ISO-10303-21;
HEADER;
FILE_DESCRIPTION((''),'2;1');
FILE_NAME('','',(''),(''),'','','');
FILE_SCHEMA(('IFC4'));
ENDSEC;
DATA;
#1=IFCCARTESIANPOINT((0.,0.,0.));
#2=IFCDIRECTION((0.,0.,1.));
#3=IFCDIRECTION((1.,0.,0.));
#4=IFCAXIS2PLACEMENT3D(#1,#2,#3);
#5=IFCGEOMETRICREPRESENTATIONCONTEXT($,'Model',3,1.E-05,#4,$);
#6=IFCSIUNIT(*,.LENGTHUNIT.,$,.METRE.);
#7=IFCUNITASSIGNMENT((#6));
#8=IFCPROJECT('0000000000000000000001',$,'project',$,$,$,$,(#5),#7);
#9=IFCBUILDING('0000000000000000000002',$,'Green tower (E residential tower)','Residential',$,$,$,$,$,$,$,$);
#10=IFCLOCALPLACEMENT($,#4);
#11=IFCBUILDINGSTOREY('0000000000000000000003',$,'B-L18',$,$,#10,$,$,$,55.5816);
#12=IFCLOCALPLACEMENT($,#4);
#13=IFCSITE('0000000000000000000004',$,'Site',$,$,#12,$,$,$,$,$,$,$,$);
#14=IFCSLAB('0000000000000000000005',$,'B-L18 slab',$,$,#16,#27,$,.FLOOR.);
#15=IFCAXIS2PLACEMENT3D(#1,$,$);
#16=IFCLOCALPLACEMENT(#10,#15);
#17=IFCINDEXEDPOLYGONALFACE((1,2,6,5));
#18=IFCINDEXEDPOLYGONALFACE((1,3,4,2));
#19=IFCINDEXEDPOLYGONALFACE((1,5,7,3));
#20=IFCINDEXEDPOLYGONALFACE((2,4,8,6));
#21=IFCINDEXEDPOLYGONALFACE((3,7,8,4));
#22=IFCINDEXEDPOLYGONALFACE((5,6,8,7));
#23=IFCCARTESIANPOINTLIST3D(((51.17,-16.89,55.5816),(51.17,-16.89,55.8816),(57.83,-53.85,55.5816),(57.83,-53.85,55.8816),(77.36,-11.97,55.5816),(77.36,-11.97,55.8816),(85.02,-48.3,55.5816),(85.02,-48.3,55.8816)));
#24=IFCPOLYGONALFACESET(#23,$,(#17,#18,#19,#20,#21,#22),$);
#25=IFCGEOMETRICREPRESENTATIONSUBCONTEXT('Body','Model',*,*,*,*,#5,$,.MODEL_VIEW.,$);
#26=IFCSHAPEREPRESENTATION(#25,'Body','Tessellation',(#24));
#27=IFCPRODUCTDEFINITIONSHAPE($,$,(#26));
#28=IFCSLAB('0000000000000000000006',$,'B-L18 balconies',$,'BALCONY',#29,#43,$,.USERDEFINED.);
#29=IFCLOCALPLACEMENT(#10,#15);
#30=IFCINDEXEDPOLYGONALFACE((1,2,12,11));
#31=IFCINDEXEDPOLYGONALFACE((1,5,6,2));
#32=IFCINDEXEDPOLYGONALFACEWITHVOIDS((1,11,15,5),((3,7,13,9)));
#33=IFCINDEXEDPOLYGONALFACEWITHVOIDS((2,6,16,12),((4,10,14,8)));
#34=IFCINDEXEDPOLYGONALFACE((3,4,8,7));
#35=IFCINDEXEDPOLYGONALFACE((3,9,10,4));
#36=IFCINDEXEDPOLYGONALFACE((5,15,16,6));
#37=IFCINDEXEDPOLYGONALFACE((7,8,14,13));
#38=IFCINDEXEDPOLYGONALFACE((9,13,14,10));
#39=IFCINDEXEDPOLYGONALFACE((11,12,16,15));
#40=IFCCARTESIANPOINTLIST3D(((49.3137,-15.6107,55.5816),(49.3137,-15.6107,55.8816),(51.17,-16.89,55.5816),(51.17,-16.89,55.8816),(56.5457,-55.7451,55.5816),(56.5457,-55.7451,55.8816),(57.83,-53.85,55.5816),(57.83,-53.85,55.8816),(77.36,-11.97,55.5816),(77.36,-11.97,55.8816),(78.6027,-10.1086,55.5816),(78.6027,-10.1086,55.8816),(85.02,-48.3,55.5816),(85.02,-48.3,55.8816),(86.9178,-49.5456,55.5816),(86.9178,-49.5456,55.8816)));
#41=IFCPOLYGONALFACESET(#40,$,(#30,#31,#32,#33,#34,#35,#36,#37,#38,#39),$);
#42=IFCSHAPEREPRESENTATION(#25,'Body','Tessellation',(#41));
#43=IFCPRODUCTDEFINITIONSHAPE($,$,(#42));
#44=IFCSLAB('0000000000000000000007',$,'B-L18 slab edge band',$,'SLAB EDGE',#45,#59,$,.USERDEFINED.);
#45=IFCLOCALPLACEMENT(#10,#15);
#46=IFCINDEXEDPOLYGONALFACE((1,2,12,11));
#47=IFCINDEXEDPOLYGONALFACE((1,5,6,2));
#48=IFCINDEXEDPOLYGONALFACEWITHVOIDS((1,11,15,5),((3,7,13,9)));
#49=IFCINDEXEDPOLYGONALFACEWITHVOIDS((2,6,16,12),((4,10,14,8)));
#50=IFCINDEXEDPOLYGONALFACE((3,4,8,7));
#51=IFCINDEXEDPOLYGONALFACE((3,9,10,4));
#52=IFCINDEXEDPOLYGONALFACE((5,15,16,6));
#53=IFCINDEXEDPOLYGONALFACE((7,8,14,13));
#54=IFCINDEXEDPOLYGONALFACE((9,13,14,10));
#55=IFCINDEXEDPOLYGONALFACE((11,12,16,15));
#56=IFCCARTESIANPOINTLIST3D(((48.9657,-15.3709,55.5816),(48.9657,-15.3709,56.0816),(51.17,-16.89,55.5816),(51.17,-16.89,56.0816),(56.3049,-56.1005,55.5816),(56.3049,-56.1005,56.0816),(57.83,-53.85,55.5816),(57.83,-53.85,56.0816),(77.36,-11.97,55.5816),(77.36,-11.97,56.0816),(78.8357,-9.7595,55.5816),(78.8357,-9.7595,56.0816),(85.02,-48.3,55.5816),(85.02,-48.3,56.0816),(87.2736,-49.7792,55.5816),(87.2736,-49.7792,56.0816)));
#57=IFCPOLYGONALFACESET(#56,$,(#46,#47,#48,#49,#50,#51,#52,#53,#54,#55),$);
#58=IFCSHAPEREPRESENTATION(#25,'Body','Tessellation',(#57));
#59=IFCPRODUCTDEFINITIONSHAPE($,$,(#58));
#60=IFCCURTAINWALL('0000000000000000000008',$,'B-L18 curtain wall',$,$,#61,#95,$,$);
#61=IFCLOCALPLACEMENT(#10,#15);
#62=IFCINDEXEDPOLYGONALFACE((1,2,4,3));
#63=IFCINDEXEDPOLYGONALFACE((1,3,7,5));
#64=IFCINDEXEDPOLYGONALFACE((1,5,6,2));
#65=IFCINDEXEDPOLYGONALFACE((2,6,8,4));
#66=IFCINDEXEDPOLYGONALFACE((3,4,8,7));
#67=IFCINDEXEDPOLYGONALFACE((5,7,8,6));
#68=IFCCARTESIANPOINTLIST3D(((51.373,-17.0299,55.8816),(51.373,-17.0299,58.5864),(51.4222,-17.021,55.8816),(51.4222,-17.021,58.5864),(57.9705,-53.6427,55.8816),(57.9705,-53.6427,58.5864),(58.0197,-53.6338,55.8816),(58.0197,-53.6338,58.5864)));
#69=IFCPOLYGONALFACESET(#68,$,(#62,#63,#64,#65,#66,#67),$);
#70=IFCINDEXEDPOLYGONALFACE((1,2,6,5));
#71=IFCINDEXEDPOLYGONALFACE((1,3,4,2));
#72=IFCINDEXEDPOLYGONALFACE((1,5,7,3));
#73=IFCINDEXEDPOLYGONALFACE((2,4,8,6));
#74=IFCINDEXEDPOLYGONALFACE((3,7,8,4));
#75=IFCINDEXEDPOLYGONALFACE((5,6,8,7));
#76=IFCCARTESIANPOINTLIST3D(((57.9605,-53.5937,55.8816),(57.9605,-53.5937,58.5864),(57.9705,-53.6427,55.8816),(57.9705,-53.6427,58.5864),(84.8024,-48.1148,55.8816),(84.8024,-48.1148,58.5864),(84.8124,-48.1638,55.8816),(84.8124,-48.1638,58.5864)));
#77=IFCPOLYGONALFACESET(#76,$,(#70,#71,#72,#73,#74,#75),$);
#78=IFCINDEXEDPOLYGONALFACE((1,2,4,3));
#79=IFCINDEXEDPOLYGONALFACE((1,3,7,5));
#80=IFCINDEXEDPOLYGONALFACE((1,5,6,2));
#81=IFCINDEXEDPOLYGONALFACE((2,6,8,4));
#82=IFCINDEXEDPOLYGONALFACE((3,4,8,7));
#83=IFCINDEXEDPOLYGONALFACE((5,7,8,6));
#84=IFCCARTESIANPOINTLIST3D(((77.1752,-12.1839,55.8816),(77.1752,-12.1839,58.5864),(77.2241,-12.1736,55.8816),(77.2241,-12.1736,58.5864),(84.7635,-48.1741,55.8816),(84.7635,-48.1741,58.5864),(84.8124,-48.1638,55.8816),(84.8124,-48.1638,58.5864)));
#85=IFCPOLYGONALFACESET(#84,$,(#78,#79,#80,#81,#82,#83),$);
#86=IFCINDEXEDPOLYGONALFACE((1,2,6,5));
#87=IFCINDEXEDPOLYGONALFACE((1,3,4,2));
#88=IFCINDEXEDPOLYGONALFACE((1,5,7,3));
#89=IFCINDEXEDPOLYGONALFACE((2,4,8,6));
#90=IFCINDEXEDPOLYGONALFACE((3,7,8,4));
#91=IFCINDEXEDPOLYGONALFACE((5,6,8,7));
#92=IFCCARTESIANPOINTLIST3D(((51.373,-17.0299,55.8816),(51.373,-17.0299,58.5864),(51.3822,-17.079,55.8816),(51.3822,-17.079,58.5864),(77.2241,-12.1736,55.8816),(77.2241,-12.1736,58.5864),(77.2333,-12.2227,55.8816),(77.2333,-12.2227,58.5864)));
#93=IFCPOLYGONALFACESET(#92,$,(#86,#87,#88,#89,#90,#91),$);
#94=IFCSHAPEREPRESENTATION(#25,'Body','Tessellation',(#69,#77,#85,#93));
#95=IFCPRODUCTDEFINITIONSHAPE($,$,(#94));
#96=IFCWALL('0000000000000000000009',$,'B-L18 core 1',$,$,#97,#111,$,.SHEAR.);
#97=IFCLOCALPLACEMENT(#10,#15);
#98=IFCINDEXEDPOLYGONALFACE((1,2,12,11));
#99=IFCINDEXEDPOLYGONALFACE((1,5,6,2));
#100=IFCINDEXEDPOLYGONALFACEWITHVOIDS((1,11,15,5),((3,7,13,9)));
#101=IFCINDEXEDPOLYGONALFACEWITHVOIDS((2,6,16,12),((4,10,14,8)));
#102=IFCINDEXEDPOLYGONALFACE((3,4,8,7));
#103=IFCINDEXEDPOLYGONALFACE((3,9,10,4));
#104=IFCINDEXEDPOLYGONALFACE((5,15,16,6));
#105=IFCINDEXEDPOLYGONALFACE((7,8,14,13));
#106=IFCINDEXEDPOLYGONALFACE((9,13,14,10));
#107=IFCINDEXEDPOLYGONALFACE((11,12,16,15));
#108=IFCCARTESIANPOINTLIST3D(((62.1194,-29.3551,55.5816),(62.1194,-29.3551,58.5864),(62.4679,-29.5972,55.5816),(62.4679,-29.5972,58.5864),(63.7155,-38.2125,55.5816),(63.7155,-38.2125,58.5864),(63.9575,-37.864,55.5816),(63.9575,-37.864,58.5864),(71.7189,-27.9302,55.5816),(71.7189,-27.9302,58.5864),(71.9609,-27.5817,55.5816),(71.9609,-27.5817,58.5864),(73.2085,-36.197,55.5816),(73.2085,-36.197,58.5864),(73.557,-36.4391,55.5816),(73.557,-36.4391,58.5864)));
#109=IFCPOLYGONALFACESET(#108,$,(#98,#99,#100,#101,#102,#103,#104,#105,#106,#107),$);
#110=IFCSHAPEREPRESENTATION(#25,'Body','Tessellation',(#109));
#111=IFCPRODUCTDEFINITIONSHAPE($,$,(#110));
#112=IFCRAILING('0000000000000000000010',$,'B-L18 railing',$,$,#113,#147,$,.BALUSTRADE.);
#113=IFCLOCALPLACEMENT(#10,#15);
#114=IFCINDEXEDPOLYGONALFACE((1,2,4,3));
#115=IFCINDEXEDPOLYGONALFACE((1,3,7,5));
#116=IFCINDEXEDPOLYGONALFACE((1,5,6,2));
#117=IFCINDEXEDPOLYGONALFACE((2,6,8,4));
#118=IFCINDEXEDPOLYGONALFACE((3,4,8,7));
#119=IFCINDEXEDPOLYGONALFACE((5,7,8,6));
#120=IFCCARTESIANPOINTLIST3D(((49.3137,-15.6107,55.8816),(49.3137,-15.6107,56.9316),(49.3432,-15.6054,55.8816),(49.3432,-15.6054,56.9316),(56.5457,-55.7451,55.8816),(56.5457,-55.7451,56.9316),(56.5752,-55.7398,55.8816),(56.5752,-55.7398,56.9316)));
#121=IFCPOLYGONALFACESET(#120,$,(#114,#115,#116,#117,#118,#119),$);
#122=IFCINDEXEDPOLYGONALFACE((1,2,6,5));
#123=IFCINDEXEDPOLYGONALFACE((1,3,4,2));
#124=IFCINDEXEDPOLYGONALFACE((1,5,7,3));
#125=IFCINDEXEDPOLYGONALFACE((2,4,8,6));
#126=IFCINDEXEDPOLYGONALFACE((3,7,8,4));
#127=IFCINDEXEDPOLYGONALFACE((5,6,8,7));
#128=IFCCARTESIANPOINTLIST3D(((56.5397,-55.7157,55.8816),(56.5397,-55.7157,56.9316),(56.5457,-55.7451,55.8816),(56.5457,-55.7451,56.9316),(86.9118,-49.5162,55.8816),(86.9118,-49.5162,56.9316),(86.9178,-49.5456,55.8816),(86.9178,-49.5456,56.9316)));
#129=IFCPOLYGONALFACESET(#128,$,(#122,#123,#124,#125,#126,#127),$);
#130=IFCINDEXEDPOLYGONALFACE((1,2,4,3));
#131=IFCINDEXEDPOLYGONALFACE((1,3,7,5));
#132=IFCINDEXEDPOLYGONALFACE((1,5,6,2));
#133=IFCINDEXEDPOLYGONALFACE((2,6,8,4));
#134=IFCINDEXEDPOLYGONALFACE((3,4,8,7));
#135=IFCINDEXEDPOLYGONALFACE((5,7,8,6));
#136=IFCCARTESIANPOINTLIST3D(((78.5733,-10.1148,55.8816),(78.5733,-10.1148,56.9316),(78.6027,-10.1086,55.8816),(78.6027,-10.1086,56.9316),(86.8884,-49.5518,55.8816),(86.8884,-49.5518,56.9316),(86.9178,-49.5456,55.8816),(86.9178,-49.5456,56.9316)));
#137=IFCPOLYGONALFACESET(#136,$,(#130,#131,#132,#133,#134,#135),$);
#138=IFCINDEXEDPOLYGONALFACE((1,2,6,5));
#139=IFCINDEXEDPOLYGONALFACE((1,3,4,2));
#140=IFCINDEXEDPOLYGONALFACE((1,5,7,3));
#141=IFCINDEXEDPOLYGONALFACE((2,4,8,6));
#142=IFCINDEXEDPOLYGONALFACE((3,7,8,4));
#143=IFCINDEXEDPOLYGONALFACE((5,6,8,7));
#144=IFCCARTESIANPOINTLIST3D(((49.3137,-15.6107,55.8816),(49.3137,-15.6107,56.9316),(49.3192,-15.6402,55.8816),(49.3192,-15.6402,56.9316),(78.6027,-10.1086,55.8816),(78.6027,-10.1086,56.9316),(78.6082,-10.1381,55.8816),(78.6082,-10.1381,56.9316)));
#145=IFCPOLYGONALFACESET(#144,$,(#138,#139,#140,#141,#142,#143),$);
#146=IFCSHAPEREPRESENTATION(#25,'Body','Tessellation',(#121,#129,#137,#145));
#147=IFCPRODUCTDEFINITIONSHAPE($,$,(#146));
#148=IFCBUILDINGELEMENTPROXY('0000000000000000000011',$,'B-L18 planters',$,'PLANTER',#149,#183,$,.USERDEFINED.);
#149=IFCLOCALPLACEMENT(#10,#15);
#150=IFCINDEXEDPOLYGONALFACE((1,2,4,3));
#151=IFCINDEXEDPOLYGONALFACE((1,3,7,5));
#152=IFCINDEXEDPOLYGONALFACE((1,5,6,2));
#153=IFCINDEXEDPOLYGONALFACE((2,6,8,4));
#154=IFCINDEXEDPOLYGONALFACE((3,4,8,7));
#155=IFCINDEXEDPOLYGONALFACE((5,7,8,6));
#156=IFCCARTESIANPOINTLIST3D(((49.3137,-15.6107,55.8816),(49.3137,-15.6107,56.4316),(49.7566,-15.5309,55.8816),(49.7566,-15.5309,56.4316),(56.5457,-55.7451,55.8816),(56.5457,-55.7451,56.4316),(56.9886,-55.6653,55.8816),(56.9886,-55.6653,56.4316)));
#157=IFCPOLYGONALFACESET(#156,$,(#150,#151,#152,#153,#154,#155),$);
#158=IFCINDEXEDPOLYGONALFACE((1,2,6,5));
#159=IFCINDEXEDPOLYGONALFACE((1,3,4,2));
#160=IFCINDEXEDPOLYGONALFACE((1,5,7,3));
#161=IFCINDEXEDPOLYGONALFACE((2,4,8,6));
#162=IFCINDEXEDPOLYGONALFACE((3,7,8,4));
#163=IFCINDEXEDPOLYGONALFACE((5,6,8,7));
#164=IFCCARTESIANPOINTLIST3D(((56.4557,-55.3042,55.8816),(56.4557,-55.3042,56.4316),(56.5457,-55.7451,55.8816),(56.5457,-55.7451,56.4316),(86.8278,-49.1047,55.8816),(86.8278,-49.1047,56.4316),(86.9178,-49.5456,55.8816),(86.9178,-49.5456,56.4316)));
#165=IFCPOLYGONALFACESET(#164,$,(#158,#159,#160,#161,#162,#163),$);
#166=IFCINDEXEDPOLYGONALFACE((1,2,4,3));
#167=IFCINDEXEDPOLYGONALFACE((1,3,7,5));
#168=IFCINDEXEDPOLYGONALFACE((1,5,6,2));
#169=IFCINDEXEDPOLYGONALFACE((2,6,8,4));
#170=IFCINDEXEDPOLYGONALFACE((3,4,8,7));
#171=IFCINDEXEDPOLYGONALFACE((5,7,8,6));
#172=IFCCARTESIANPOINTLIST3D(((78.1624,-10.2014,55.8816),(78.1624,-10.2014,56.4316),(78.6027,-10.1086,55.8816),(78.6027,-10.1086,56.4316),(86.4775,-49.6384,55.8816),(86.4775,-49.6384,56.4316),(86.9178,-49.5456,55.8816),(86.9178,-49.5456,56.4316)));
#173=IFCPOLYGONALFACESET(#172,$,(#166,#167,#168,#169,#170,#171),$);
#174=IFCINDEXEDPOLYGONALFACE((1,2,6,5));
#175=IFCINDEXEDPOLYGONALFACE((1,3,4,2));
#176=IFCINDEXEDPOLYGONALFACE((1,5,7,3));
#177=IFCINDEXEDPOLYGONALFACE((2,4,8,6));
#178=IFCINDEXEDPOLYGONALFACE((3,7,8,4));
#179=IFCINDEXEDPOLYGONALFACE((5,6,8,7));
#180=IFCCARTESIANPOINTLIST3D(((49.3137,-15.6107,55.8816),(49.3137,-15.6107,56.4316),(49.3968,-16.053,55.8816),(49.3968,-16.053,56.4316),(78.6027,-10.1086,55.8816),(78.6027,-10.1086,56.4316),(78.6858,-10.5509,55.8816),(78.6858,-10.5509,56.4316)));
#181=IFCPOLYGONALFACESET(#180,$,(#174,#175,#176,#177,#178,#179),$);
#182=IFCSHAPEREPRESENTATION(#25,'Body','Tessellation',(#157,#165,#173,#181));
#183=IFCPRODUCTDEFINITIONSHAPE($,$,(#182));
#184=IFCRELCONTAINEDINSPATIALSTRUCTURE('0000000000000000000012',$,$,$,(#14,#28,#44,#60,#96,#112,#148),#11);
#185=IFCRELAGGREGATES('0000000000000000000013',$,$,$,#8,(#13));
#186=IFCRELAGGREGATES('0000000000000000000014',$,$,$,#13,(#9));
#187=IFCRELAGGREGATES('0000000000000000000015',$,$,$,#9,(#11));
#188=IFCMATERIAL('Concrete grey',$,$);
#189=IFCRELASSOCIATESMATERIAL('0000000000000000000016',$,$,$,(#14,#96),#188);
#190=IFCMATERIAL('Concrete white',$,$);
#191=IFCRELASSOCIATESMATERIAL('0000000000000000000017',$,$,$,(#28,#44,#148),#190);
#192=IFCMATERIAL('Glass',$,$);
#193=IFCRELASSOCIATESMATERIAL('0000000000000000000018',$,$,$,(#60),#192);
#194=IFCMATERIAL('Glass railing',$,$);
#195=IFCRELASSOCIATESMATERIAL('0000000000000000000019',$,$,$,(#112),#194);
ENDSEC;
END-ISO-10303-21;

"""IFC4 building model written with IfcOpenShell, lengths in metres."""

from ifc_helpers import new_model, si_unit, frame, origin_with_axes, place, context, subcontext, project, spatial, polyline, outline, extrude, material, element, save


model = new_model("IFC4")

# Units and contexts
model_context = context("Model", 3, precision=1e-05, world=origin_with_axes())
body_context = subcontext(model_context, "Body", "Model", "MODEL_VIEW")
ifc_project = project(units=[si_unit("LENGTHUNIT", "METRE")], contexts=[model_context])

# Site, building, storey
site_placement = place(None, origin_with_axes())
site = spatial("IfcSite", under=ifc_project, at=site_placement, Name="Site")
building = spatial("IfcBuilding", under=site, Name="Green tower (E residential tower)", Description="Residential")
storey_placement = place(None, origin_with_axes())
storey = spatial("IfcBuildingStorey", under=building, at=storey_placement, Name="B-L18", Elevation=55.5816)

# Slabs
ifc_material_1 = material(Name="Concrete grey")
slab_1_placement = place(storey_placement, origin_with_axes())
element("IfcSlab", 1, at=slab_1_placement, inside=storey, material=ifc_material_1, Name="B-L18 slab", PredefinedType="FLOOR", context=body_context, shape_type="SweptSolid", body=[
    extrude(outline(polyline([(51.17, -16.89), (57.83, -53.85), (85.02, -48.3), (77.36, -11.97), (51.17, -16.89)])), frame((0.0, 0.0, 55.5816), z_axis=(0.0, 0.0, 1.0), x_axis=(1.0, 0.0, 0.0)), (0.0, 0.0, 1.0), 0.3),
])
ifc_material_2 = material(Name="Concrete white")
slab_2_placement = place(storey_placement, origin_with_axes())
element("IfcSlab", 2, at=slab_2_placement, inside=storey, material=ifc_material_2, Name="B-L18 balconies", ObjectType="BALCONY", PredefinedType="USERDEFINED", context=body_context, shape_type="SweptSolid", body=[
    extrude(outline(polyline([(49.3137, -15.6107), (56.5457, -55.7451), (86.9178, -49.5456), (78.6027, -10.1086), (49.3137, -15.6107)]), holes=[polyline([(51.17, -16.89), (57.83, -53.85), (85.02, -48.3), (77.36, -11.97), (51.17, -16.89)])]), frame((0.0, 0.0, 55.5816), z_axis=(0.0, 0.0, 1.0), x_axis=(1.0, 0.0, 0.0)), (0.0, 0.0, 1.0), 0.3),
])
slab_3_placement = place(storey_placement, origin_with_axes())
element("IfcSlab", 3, at=slab_3_placement, inside=storey, material=ifc_material_2, Name="B-L18 slab edge band", ObjectType="SLAB EDGE", PredefinedType="USERDEFINED", context=body_context, shape_type="SweptSolid", body=[
    extrude(outline(polyline([(48.9657, -15.3709), (56.3049, -56.1005), (87.2736, -49.7792), (78.8357, -9.7595), (48.9657, -15.3709)]), holes=[polyline([(51.17, -16.89), (57.83, -53.85), (85.02, -48.3), (77.36, -11.97), (51.17, -16.89)])]), frame((0.0, 0.0, 55.5816), z_axis=(0.0, 0.0, 1.0), x_axis=(1.0, 0.0, 0.0)), (0.0, 0.0, 1.0), 0.5),
])

# Curtain wall
ifc_material_3 = material(Name="Glass")
curtain_wall_placement = place(storey_placement, origin_with_axes())
element("IfcCurtainWall", 4, at=curtain_wall_placement, inside=storey, material=ifc_material_3, Name="B-L18 curtain wall", context=body_context, shape_type="SweptSolid", body=[
    extrude(outline(polyline([(51.373, -17.0299), (57.9705, -53.6427), (58.0197, -53.6338), (51.4222, -17.021), (51.373, -17.0299)])), frame((0.0, 0.0, 55.8816), z_axis=(0.0, 0.0, 1.0), x_axis=(1.0, 0.0, 0.0)), (0.0, 0.0, 1.0), 2.7048),
    extrude(outline(polyline([(57.9705, -53.6427), (84.8124, -48.1638), (84.8024, -48.1148), (57.9605, -53.5937), (57.9705, -53.6427)])), frame((0.0, 0.0, 55.8816), z_axis=(0.0, 0.0, 1.0), x_axis=(1.0, 0.0, 0.0)), (0.0, 0.0, 1.0), 2.7048),
    extrude(outline(polyline([(84.8124, -48.1638), (77.2241, -12.1736), (77.1752, -12.1839), (84.7635, -48.1741), (84.8124, -48.1638)])), frame((0.0, 0.0, 55.8816), z_axis=(0.0, 0.0, 1.0), x_axis=(1.0, 0.0, 0.0)), (0.0, 0.0, 1.0), 2.7048),
    extrude(outline(polyline([(77.2241, -12.1736), (51.373, -17.0299), (51.3822, -17.079), (77.2333, -12.2227), (77.2241, -12.1736)])), frame((0.0, 0.0, 55.8816), z_axis=(0.0, 0.0, 1.0), x_axis=(1.0, 0.0, 0.0)), (0.0, 0.0, 1.0), 2.7048),
])

# Wall
wall_placement = place(storey_placement, origin_with_axes())
element("IfcWall", 5, at=wall_placement, inside=storey, material=ifc_material_1, Name="B-L18 core 1", PredefinedType="SHEAR", context=body_context, shape_type="SweptSolid", body=[
    extrude(outline(polyline([(62.1194, -29.3551), (63.7155, -38.2125), (73.557, -36.4391), (71.9609, -27.5817), (62.1194, -29.3551)]), holes=[polyline([(62.4679, -29.5972), (63.9575, -37.864), (73.2085, -36.197), (71.7189, -27.9302), (62.4679, -29.5972)])]), frame((0.0, 0.0, 55.5816), z_axis=(0.0, 0.0, 1.0), x_axis=(1.0, 0.0, 0.0)), (0.0, 0.0, 1.0), 3.0048),
])

# Railing
ifc_material_4 = material(Name="Glass railing")
railing_placement = place(storey_placement, origin_with_axes())
element("IfcRailing", 6, at=railing_placement, inside=storey, material=ifc_material_4, Name="B-L18 railing", PredefinedType="BALUSTRADE", context=body_context, shape_type="SweptSolid", body=[
    extrude(outline(polyline([(49.3137, -15.6107), (56.5457, -55.7451), (56.5752, -55.7398), (49.3432, -15.6054), (49.3137, -15.6107)])), frame((0.0, 0.0, 55.8816), z_axis=(0.0, 0.0, 1.0), x_axis=(1.0, 0.0, 0.0)), (0.0, 0.0, 1.0), 1.05),
    extrude(outline(polyline([(56.5457, -55.7451), (86.9178, -49.5456), (86.9118, -49.5162), (56.5397, -55.7157), (56.5457, -55.7451)])), frame((0.0, 0.0, 55.8816), z_axis=(0.0, 0.0, 1.0), x_axis=(1.0, 0.0, 0.0)), (0.0, 0.0, 1.0), 1.05),
    extrude(outline(polyline([(86.9178, -49.5456), (78.6027, -10.1086), (78.5733, -10.1148), (86.8884, -49.5518), (86.9178, -49.5456)])), frame((0.0, 0.0, 55.8816), z_axis=(0.0, 0.0, 1.0), x_axis=(1.0, 0.0, 0.0)), (0.0, 0.0, 1.0), 1.05),
    extrude(outline(polyline([(78.6027, -10.1086), (49.3137, -15.6107), (49.3192, -15.6402), (78.6082, -10.1381), (78.6027, -10.1086)])), frame((0.0, 0.0, 55.8816), z_axis=(0.0, 0.0, 1.0), x_axis=(1.0, 0.0, 0.0)), (0.0, 0.0, 1.0), 1.05),
])

# Building element proxy
proxy_1_placement = place(storey_placement, origin_with_axes())
element("IfcBuildingElementProxy", 7, at=proxy_1_placement, inside=storey, material=ifc_material_2, Name="B-L18 planters", ObjectType="PLANTER", PredefinedType="USERDEFINED", context=body_context, shape_type="SweptSolid", body=[
    extrude(outline(polyline([(49.3137, -15.6107), (56.5457, -55.7451), (56.9886, -55.6653), (49.7566, -15.5309), (49.3137, -15.6107)])), frame((0.0, 0.0, 55.8816), z_axis=(0.0, 0.0, 1.0), x_axis=(1.0, 0.0, 0.0)), (0.0, 0.0, 1.0), 0.55),
    extrude(outline(polyline([(56.5457, -55.7451), (86.9178, -49.5456), (86.8278, -49.1047), (56.4557, -55.3042), (56.5457, -55.7451)])), frame((0.0, 0.0, 55.8816), z_axis=(0.0, 0.0, 1.0), x_axis=(1.0, 0.0, 0.0)), (0.0, 0.0, 1.0), 0.55),
    extrude(outline(polyline([(86.9178, -49.5456), (78.6027, -10.1086), (78.1624, -10.2014), (86.4775, -49.6384), (86.9178, -49.5456)])), frame((0.0, 0.0, 55.8816), z_axis=(0.0, 0.0, 1.0), x_axis=(1.0, 0.0, 0.0)), (0.0, 0.0, 1.0), 0.55),
    extrude(outline(polyline([(78.6027, -10.1086), (49.3137, -15.6107), (49.3968, -16.053), (78.6858, -10.5509), (78.6027, -10.1086)])), frame((0.0, 0.0, 55.8816), z_axis=(0.0, 0.0, 1.0), x_axis=(1.0, 0.0, 0.0)), (0.0, 0.0, 1.0), 0.55),
])

save(model, "model.ifc")
